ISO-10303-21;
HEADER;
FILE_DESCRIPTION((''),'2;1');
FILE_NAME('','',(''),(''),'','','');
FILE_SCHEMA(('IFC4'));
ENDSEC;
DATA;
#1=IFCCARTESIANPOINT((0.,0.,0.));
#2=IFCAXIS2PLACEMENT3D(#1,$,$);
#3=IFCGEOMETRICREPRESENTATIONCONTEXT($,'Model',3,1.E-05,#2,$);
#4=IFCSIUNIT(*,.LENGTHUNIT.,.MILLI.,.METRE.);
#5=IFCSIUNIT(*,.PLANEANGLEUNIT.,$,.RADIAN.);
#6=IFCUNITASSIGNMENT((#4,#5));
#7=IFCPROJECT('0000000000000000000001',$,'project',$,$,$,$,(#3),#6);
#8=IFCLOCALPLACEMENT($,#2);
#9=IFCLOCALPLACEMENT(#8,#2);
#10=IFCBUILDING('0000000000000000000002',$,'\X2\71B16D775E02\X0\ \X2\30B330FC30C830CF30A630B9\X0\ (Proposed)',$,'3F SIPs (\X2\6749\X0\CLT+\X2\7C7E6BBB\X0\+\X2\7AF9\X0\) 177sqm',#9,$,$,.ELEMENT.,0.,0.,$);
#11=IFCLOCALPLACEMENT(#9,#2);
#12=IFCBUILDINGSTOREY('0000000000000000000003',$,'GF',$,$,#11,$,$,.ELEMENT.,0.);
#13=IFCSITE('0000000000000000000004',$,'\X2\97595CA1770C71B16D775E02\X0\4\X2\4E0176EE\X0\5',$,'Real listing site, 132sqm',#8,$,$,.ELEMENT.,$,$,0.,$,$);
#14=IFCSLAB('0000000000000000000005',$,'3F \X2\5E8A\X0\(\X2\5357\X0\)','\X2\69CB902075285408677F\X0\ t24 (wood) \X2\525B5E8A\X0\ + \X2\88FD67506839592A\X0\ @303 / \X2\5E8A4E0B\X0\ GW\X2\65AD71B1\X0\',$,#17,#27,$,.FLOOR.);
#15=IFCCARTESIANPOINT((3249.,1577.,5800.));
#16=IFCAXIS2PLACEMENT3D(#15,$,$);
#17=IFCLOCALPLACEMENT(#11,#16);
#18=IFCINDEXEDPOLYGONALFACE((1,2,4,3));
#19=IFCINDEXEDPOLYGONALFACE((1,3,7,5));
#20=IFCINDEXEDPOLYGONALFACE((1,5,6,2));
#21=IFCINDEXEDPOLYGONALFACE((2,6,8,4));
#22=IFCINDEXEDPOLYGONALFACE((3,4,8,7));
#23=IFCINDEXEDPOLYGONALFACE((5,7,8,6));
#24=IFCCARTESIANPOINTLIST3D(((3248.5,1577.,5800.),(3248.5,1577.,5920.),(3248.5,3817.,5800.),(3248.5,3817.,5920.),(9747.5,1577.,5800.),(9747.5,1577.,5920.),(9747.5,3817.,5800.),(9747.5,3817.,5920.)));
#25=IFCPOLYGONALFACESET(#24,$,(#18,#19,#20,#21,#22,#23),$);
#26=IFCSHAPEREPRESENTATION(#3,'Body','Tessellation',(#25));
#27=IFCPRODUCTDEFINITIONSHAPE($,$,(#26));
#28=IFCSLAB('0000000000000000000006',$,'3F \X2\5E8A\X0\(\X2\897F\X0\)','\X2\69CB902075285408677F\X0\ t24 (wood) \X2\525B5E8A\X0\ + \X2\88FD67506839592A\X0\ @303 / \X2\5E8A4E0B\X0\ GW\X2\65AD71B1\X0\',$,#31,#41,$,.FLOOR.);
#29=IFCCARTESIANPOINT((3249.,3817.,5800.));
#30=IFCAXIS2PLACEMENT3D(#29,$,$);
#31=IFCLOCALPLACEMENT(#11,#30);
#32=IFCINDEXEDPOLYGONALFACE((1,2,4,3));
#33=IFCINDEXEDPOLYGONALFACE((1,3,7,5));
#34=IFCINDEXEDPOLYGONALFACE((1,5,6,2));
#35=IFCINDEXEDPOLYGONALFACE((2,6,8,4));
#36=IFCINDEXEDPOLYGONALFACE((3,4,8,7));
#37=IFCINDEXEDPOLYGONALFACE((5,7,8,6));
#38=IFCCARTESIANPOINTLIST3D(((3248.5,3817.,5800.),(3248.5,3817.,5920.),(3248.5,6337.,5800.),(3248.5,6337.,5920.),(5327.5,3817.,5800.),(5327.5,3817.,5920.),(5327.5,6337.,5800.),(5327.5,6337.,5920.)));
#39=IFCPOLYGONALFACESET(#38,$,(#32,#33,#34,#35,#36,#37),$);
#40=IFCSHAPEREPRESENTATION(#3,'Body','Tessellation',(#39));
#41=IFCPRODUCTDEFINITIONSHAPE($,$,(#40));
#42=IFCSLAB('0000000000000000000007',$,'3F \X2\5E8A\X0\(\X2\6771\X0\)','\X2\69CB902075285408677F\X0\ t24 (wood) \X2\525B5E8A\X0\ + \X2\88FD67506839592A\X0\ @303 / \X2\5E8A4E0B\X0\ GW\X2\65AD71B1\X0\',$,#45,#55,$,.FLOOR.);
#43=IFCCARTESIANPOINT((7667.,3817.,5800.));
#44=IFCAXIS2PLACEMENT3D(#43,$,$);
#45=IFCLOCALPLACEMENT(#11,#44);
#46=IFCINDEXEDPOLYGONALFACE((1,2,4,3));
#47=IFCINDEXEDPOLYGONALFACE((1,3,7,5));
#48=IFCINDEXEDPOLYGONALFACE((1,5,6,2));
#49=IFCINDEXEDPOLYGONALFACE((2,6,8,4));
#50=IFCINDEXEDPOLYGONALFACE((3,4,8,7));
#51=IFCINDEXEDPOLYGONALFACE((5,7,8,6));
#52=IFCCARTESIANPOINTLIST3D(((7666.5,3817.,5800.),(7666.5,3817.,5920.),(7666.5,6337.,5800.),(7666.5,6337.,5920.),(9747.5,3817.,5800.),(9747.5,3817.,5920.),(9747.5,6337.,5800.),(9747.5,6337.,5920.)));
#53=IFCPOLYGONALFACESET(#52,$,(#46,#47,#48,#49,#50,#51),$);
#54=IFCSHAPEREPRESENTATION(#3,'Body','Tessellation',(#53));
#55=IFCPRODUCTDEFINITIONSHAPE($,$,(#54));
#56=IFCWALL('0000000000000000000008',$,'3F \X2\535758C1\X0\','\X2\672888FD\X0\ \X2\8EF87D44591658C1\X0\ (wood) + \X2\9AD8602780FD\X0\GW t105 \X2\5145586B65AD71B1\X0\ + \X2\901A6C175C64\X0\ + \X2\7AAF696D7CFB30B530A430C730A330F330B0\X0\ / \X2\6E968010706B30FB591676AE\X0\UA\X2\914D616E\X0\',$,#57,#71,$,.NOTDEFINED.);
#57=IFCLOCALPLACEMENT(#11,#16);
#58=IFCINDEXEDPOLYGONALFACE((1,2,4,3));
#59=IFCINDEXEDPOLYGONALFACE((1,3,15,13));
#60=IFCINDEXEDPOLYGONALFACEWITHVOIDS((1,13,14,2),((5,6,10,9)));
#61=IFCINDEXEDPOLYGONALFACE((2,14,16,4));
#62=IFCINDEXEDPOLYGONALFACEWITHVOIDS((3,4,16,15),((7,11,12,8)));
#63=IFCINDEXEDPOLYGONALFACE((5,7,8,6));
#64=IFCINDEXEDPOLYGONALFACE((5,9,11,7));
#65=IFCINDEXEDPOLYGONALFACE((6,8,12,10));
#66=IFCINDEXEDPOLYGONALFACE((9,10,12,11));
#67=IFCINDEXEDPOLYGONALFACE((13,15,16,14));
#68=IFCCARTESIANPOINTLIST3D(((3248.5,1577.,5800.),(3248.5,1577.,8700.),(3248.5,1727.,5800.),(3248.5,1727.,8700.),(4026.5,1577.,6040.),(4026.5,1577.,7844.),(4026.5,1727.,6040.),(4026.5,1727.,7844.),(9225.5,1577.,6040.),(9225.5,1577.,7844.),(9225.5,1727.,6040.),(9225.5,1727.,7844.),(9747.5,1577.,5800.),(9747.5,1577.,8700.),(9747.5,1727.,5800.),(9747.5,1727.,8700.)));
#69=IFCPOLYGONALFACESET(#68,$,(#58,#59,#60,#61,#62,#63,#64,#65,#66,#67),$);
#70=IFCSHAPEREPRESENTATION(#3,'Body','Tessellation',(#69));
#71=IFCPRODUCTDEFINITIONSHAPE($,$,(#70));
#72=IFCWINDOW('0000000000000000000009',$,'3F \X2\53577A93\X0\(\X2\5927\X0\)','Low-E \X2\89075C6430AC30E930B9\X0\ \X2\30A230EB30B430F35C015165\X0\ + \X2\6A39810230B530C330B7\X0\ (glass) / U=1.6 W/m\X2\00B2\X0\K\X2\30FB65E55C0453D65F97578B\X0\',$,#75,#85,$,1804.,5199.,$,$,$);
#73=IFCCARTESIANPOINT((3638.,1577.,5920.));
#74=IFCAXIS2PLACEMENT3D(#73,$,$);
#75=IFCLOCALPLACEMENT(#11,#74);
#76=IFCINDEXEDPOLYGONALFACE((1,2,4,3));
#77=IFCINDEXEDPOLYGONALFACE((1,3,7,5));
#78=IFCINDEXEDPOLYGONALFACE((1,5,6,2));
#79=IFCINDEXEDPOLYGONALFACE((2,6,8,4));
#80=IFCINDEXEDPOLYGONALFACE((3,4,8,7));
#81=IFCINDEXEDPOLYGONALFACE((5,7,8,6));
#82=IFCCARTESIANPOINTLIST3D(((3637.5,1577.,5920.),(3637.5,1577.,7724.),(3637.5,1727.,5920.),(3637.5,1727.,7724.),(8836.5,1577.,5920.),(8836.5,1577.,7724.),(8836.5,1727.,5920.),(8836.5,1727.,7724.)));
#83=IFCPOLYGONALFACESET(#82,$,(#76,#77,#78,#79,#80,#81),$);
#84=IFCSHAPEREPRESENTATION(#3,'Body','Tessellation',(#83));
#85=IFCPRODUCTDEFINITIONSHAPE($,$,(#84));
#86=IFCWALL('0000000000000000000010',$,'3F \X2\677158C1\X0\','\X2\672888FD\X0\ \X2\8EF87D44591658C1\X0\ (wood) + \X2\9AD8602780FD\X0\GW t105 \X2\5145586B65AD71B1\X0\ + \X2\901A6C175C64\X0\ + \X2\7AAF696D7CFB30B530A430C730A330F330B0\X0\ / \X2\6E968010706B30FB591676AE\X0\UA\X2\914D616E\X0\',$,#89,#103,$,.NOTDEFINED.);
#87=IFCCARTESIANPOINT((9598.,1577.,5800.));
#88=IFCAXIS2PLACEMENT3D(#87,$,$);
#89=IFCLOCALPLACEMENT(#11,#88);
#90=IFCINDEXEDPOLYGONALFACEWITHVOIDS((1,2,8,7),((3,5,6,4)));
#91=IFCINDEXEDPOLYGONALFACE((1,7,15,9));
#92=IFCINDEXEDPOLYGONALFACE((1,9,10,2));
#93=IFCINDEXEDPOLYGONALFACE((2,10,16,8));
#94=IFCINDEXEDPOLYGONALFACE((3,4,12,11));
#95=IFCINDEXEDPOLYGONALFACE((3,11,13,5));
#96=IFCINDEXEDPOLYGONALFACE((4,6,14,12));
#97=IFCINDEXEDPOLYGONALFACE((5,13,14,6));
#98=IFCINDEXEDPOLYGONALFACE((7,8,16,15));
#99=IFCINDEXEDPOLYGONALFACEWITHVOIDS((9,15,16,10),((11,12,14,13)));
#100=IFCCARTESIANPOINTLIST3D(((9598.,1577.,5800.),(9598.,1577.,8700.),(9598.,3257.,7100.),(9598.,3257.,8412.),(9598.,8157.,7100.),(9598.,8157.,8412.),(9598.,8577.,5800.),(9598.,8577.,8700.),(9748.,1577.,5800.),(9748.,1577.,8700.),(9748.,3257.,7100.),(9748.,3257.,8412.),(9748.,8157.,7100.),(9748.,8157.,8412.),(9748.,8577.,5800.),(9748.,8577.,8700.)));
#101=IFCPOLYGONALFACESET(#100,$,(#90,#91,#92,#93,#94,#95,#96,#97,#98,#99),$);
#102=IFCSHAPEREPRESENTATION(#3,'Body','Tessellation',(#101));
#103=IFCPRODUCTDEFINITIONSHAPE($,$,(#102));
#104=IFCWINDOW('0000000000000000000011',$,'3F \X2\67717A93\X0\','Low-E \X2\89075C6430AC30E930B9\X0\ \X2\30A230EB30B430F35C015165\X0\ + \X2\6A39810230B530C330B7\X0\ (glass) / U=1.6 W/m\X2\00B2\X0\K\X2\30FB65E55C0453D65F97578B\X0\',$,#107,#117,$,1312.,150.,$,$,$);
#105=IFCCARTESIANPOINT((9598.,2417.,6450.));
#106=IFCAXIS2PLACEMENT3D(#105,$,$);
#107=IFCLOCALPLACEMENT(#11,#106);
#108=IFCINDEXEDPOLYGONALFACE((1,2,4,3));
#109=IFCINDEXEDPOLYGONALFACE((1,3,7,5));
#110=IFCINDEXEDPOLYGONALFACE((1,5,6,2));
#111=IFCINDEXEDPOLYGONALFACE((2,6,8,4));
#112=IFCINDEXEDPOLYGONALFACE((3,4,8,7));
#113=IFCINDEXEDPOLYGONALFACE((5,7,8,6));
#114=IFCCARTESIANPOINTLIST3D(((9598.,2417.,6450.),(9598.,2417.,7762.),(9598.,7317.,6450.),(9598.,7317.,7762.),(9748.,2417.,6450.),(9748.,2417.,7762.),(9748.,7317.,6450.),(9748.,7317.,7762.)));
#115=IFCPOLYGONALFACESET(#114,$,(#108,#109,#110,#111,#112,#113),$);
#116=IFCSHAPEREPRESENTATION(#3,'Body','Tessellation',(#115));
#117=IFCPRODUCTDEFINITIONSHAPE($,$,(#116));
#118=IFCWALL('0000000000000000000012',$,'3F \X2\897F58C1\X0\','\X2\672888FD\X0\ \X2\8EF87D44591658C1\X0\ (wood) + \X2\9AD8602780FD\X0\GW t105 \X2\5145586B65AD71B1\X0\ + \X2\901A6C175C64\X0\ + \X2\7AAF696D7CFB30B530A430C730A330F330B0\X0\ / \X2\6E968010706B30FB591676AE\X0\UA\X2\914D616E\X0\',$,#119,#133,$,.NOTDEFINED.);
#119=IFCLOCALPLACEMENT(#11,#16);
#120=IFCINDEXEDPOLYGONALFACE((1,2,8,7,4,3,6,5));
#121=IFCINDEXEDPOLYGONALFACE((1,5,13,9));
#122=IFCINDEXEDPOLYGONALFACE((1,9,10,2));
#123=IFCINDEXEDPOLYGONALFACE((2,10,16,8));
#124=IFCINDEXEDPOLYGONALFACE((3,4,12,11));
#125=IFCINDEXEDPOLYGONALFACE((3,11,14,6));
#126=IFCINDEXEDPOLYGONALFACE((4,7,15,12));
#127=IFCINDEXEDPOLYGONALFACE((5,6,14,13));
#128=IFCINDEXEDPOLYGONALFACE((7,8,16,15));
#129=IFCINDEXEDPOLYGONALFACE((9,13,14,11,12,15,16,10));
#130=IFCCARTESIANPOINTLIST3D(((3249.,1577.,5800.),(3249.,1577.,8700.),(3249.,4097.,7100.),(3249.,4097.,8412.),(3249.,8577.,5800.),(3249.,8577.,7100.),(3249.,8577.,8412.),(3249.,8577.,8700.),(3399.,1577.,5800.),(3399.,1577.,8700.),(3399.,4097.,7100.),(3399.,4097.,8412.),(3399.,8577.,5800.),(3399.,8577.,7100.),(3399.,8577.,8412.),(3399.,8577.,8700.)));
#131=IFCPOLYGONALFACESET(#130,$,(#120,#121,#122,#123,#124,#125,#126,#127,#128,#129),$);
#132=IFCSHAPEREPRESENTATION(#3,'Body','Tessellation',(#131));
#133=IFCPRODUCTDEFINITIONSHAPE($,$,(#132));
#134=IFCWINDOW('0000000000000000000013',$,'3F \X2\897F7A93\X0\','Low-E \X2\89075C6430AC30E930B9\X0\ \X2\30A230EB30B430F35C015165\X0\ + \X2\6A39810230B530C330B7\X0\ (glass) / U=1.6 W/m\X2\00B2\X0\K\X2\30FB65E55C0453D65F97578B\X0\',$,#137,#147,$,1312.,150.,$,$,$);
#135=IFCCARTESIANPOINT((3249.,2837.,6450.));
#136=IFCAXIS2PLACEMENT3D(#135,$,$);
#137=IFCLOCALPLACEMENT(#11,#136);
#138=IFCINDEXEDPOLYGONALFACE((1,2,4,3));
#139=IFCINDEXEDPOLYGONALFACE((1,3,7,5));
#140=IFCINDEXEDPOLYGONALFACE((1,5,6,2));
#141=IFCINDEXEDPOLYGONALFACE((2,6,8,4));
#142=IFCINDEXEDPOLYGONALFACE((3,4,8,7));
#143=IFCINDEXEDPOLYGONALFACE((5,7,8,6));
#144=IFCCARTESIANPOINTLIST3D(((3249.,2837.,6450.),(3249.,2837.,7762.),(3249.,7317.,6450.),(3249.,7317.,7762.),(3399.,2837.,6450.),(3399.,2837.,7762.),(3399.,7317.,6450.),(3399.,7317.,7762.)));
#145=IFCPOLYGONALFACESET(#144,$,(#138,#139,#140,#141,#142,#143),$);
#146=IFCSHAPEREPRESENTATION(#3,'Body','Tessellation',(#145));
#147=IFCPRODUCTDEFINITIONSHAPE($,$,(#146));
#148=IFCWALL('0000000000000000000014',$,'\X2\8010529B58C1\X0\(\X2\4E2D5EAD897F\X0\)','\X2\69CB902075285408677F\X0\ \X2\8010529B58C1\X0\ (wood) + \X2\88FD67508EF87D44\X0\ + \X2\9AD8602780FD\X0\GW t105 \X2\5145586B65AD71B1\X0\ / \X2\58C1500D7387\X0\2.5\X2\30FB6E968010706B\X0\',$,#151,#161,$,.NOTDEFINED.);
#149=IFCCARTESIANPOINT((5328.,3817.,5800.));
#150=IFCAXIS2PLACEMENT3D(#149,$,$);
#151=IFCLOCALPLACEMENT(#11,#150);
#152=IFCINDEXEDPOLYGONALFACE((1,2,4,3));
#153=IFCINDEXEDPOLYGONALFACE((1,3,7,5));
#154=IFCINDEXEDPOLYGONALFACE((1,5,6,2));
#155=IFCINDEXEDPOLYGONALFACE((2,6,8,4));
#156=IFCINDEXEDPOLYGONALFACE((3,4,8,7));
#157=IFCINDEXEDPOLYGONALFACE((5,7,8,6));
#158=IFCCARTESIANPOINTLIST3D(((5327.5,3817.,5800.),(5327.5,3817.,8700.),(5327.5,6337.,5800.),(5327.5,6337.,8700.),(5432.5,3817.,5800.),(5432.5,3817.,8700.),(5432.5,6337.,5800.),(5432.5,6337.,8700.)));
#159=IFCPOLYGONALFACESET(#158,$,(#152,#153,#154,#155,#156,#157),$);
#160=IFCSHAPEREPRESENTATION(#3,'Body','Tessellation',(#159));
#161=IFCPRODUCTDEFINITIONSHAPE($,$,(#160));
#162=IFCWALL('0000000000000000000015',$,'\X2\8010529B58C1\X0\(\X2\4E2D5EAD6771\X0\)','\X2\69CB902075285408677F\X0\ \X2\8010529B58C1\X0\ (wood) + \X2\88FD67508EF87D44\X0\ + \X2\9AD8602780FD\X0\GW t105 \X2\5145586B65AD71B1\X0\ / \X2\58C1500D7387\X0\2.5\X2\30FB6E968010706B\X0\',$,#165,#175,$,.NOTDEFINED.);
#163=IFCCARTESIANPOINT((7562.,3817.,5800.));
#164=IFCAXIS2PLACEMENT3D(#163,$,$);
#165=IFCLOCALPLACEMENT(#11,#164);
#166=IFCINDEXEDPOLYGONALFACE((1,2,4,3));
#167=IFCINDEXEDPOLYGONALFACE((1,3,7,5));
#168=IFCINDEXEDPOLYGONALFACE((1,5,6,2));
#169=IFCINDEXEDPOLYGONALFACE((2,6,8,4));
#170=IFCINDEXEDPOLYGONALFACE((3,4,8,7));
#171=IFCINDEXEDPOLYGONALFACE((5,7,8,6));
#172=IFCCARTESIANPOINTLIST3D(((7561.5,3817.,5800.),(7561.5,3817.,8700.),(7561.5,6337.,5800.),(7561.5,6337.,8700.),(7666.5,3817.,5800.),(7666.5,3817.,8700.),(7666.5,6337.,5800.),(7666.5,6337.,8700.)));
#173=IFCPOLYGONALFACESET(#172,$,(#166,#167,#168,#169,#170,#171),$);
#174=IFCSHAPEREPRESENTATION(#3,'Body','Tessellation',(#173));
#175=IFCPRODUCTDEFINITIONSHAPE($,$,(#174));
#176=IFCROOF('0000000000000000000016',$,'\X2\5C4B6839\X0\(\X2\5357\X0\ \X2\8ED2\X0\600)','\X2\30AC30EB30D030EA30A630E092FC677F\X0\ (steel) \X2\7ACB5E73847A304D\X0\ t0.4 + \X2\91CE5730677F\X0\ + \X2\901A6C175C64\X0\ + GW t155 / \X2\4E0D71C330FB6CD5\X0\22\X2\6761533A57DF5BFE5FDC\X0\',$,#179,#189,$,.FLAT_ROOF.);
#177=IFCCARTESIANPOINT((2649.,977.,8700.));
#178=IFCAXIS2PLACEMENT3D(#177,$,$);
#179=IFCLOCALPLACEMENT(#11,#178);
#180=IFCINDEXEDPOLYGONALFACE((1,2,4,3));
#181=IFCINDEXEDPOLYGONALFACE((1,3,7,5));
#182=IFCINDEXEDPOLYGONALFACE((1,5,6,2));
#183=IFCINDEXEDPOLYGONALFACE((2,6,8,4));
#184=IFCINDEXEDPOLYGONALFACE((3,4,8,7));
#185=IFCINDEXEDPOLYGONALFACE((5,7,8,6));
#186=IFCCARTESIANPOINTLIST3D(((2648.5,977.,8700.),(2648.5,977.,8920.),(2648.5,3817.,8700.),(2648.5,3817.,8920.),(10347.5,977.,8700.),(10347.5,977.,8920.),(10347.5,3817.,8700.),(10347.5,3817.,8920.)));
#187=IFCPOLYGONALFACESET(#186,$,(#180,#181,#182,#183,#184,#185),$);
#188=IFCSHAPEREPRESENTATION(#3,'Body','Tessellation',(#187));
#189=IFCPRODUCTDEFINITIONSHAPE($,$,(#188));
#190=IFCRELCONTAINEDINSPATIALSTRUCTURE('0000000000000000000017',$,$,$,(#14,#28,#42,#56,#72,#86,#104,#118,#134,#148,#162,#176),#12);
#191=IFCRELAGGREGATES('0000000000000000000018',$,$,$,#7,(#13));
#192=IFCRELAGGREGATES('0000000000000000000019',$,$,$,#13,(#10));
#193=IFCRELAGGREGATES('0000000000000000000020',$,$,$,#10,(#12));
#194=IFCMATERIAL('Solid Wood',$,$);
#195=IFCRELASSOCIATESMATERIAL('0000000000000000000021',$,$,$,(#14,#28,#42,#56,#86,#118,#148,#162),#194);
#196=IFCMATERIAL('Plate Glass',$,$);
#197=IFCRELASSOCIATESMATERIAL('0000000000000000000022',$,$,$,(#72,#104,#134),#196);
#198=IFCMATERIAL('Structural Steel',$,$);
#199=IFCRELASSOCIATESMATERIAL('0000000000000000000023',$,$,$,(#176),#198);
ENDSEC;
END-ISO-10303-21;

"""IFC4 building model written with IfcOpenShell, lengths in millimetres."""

from ifc_helpers import new_model, si_unit, frame, frame_2d, origin, place, context, project, spatial, rectangle, extrude, material, element, fill, save


model = new_model("IFC4")

# Units and contexts
model_context = context("Model", 3, precision=1e-05, world=origin())
ifc_project = project(units=[si_unit("LENGTHUNIT", "METRE", prefix="MILLI"), si_unit("PLANEANGLEUNIT", "RADIAN")], contexts=[model_context])

# Site, building, storey
site_placement = place(None, origin())
site = spatial("IfcSite", under=ifc_project, at=site_placement, Name="静岡県熱海市4丁目5", ObjectType="Real listing site, 132sqm", CompositionType="ELEMENT", RefElevation=0.0)
building_placement = place(site_placement, origin())
building = spatial("IfcBuilding", under=site, at=building_placement, Name="熱海市 コートハウス (Proposed)", ObjectType="3F SIPs (杉CLT+籾殻+竹) 177sqm", CompositionType="ELEMENT", ElevationOfRefHeight=0.0, ElevationOfTerrain=0.0)
storey_placement = place(building_placement, origin())
storey = spatial("IfcBuildingStorey", under=building, at=storey_placement, Name="GF", CompositionType="ELEMENT", Elevation=0.0)

# Slabs
ifc_material_1 = material(Name="Solid Wood")
slab_1_placement = place(storey_placement, frame((3249.0, 1577.0, 5800.0)))
element("IfcSlab", 1, at=slab_1_placement, inside=storey, material=ifc_material_1, Name="3F 床(南)", Description="構造用合板 t24 (wood) 剛床 + 製材根太 @303 / 床下 GW断熱", PredefinedType="FLOOR", context=model_context, shape_type="SweptSolid", body=[
    extrude(rectangle(XDim=6499.0, YDim=2240.0, at=frame_2d((3249.0, 1120.0))), frame((3249.0, 1577.0, 5800.0)), (0.0, 0.0, 1.0), 120.0),
])
slab_2_placement = place(storey_placement, frame((3249.0, 3817.0, 5800.0)))
element("IfcSlab", 2, at=slab_2_placement, inside=storey, material=ifc_material_1, Name="3F 床(西)", Description="構造用合板 t24 (wood) 剛床 + 製材根太 @303 / 床下 GW断熱", PredefinedType="FLOOR", context=model_context, shape_type="SweptSolid", body=[
    extrude(rectangle(XDim=2079.0, YDim=2520.0, at=frame_2d((1039.0, 1260.0))), frame((3249.0, 3817.0, 5800.0)), (0.0, 0.0, 1.0), 120.0),
])
slab_3_placement = place(storey_placement, frame((7667.0, 3817.0, 5800.0)))
element("IfcSlab", 3, at=slab_3_placement, inside=storey, material=ifc_material_1, Name="3F 床(東)", Description="構造用合板 t24 (wood) 剛床 + 製材根太 @303 / 床下 GW断熱", PredefinedType="FLOOR", context=model_context, shape_type="SweptSolid", body=[
    extrude(rectangle(XDim=2081.0, YDim=2520.0, at=frame_2d((1040.0, 1260.0))), frame((7667.0, 3817.0, 5800.0)), (0.0, 0.0, 1.0), 120.0),
])

# Walls, openings, windows
wall_1_placement = place(storey_placement, frame((3249.0, 1577.0, 5800.0)))
wall_1 = element("IfcWall", 4, at=wall_1_placement, inside=storey, material=ifc_material_1, Name="3F 南壁", Description="木製 軸組外壁 (wood) + 高性能GW t105 充填断熱 + 通気層 + 窯業系サイディング / 準耐火・外皮UA配慮", PredefinedType="NOTDEFINED", context=model_context, shape_type="SweptSolid", body=[
    extrude(rectangle(XDim=6499.0, YDim=150.0, at=frame_2d((3249.0, 75.0))), frame((3249.0, 1577.0, 5800.0)), (0.0, 0.0, 1.0), 2900.0),
])
opening_1_placement = place(storey_placement, frame((3638.0, 1577.0, 5920.0)))
opening_1 = element("IfcOpeningElement", 5, at=opening_1_placement, cuts=wall_1, PredefinedType="NOTDEFINED", context=model_context, shape_type="SweptSolid", body=[
    extrude(rectangle(XDim=5199.0, YDim=150.0, at=frame_2d((2599.0, 75.0))), frame((3638.0, 1577.0, 5920.0)), (0.0, 0.0, 1.0), 1804.0),
])
ifc_material_2 = material(Name="Plate Glass")
window_1_placement = place(storey_placement, frame((3638.0, 1577.0, 5920.0)))
window_1 = element("IfcWindow", 6, at=window_1_placement, inside=storey, material=ifc_material_2, Name="3F 南窓(大)", Description="Low-E 複層ガラス アルゴン封入 + 樹脂サッシ (glass) / U=1.6 W/m²K・日射取得型", OverallHeight=1804.0, OverallWidth=5199.0, context=model_context, shape_type="SweptSolid", body=[
    extrude(rectangle(XDim=5199.0, YDim=150.0, at=frame_2d((2599.0, 75.0))), frame((3638.0, 1577.0, 5920.0)), (0.0, 0.0, 1.0), 1804.0),
])
fill(opening_1, window_1)
wall_2_placement = place(storey_placement, frame((9598.0, 1577.0, 5800.0)))
wall_2 = element("IfcWall", 7, at=wall_2_placement, inside=storey, material=ifc_material_1, Name="3F 東壁", Description="木製 軸組外壁 (wood) + 高性能GW t105 充填断熱 + 通気層 + 窯業系サイディング / 準耐火・外皮UA配慮", PredefinedType="NOTDEFINED", context=model_context, shape_type="SweptSolid", body=[
    extrude(rectangle(XDim=150.0, YDim=7000.0, at=frame_2d((75.0, 3500.0))), frame((9598.0, 1577.0, 5800.0)), (0.0, 0.0, 1.0), 2900.0),
])
opening_2_placement = place(storey_placement, frame((9598.0, 2417.0, 6450.0)))
opening_2 = element("IfcOpeningElement", 8, at=opening_2_placement, cuts=wall_2, PredefinedType="NOTDEFINED", context=model_context, shape_type="SweptSolid", body=[
    extrude(rectangle(XDim=150.0, YDim=4900.0, at=frame_2d((75.0, 2450.0))), frame((9598.0, 2417.0, 6450.0)), (0.0, 0.0, 1.0), 1312.0),
])
window_2_placement = place(storey_placement, frame((9598.0, 2417.0, 6450.0)))
window_2 = element("IfcWindow", 9, at=window_2_placement, inside=storey, material=ifc_material_2, Name="3F 東窓", Description="Low-E 複層ガラス アルゴン封入 + 樹脂サッシ (glass) / U=1.6 W/m²K・日射取得型", OverallHeight=1312.0, OverallWidth=150.0, context=model_context, shape_type="SweptSolid", body=[
    extrude(rectangle(XDim=150.0, YDim=4900.0, at=frame_2d((75.0, 2450.0))), frame((9598.0, 2417.0, 6450.0)), (0.0, 0.0, 1.0), 1312.0),
])
fill(opening_2, window_2)
wall_3_placement = place(storey_placement, frame((3249.0, 1577.0, 5800.0)))
wall_3 = element("IfcWall", 10, at=wall_3_placement, inside=storey, material=ifc_material_1, Name="3F 西壁", Description="木製 軸組外壁 (wood) + 高性能GW t105 充填断熱 + 通気層 + 窯業系サイディング / 準耐火・外皮UA配慮", PredefinedType="NOTDEFINED", context=model_context, shape_type="SweptSolid", body=[
    extrude(rectangle(XDim=150.0, YDim=7000.0, at=frame_2d((75.0, 3500.0))), frame((3249.0, 1577.0, 5800.0)), (0.0, 0.0, 1.0), 2900.0),
])
opening_3_placement = place(storey_placement, frame((3249.0, 2837.0, 6450.0)))
opening_3 = element("IfcOpeningElement", 11, at=opening_3_placement, cuts=wall_3, PredefinedType="NOTDEFINED", context=model_context, shape_type="SweptSolid", body=[
    extrude(rectangle(XDim=150.0, YDim=4480.0, at=frame_2d((75.0, 2240.0))), frame((3249.0, 2837.0, 6450.0)), (0.0, 0.0, 1.0), 1312.0),
])
window_3_placement = place(storey_placement, frame((3249.0, 2837.0, 6450.0)))
window_3 = element("IfcWindow", 12, at=window_3_placement, inside=storey, material=ifc_material_2, Name="3F 西窓", Description="Low-E 複層ガラス アルゴン封入 + 樹脂サッシ (glass) / U=1.6 W/m²K・日射取得型", OverallHeight=1312.0, OverallWidth=150.0, context=model_context, shape_type="SweptSolid", body=[
    extrude(rectangle(XDim=150.0, YDim=4480.0, at=frame_2d((75.0, 2240.0))), frame((3249.0, 2837.0, 6450.0)), (0.0, 0.0, 1.0), 1312.0),
])
fill(opening_3, window_3)

# Walls
wall_4_placement = place(storey_placement, frame((5328.0, 3817.0, 5800.0)))
element("IfcWall", 13, at=wall_4_placement, inside=storey, material=ifc_material_1, Name="耐力壁(中庭西)", Description="構造用合板 耐力壁 (wood) + 製材軸組 + 高性能GW t105 充填断熱 / 壁倍率2.5・準耐火", PredefinedType="NOTDEFINED", context=model_context, shape_type="SweptSolid", body=[
    extrude(rectangle(XDim=105.0, YDim=2520.0, at=frame_2d((52.0, 1260.0))), frame((5328.0, 3817.0, 5800.0)), (0.0, 0.0, 1.0), 2900.0),
])
wall_5_placement = place(storey_placement, frame((7562.0, 3817.0, 5800.0)))
element("IfcWall", 14, at=wall_5_placement, inside=storey, material=ifc_material_1, Name="耐力壁(中庭東)", Description="構造用合板 耐力壁 (wood) + 製材軸組 + 高性能GW t105 充填断熱 / 壁倍率2.5・準耐火", PredefinedType="NOTDEFINED", context=model_context, shape_type="SweptSolid", body=[
    extrude(rectangle(XDim=105.0, YDim=2520.0, at=frame_2d((52.0, 1260.0))), frame((7562.0, 3817.0, 5800.0)), (0.0, 0.0, 1.0), 2900.0),
])

# Roof
ifc_material_3 = material(Name="Structural Steel")
roof_1_placement = place(storey_placement, frame((2649.0, 977.0, 8700.0)))
element("IfcRoof", 15, at=roof_1_placement, inside=storey, material=ifc_material_3, Name="屋根(南 軒600)", Description="ガルバリウム鋼板 (steel) 立平葺き t0.4 + 野地板 + 通気層 + GW t155 / 不燃・法22条区域対応", PredefinedType="FLAT_ROOF", context=model_context, shape_type="SweptSolid", body=[
    extrude(rectangle(XDim=7699.0, YDim=2840.0, at=frame_2d((3849.0, 1420.0))), frame((2649.0, 977.0, 8700.0)), (0.0, 0.0, 1.0), 220.0),
])

save(model, "model.ifc")
